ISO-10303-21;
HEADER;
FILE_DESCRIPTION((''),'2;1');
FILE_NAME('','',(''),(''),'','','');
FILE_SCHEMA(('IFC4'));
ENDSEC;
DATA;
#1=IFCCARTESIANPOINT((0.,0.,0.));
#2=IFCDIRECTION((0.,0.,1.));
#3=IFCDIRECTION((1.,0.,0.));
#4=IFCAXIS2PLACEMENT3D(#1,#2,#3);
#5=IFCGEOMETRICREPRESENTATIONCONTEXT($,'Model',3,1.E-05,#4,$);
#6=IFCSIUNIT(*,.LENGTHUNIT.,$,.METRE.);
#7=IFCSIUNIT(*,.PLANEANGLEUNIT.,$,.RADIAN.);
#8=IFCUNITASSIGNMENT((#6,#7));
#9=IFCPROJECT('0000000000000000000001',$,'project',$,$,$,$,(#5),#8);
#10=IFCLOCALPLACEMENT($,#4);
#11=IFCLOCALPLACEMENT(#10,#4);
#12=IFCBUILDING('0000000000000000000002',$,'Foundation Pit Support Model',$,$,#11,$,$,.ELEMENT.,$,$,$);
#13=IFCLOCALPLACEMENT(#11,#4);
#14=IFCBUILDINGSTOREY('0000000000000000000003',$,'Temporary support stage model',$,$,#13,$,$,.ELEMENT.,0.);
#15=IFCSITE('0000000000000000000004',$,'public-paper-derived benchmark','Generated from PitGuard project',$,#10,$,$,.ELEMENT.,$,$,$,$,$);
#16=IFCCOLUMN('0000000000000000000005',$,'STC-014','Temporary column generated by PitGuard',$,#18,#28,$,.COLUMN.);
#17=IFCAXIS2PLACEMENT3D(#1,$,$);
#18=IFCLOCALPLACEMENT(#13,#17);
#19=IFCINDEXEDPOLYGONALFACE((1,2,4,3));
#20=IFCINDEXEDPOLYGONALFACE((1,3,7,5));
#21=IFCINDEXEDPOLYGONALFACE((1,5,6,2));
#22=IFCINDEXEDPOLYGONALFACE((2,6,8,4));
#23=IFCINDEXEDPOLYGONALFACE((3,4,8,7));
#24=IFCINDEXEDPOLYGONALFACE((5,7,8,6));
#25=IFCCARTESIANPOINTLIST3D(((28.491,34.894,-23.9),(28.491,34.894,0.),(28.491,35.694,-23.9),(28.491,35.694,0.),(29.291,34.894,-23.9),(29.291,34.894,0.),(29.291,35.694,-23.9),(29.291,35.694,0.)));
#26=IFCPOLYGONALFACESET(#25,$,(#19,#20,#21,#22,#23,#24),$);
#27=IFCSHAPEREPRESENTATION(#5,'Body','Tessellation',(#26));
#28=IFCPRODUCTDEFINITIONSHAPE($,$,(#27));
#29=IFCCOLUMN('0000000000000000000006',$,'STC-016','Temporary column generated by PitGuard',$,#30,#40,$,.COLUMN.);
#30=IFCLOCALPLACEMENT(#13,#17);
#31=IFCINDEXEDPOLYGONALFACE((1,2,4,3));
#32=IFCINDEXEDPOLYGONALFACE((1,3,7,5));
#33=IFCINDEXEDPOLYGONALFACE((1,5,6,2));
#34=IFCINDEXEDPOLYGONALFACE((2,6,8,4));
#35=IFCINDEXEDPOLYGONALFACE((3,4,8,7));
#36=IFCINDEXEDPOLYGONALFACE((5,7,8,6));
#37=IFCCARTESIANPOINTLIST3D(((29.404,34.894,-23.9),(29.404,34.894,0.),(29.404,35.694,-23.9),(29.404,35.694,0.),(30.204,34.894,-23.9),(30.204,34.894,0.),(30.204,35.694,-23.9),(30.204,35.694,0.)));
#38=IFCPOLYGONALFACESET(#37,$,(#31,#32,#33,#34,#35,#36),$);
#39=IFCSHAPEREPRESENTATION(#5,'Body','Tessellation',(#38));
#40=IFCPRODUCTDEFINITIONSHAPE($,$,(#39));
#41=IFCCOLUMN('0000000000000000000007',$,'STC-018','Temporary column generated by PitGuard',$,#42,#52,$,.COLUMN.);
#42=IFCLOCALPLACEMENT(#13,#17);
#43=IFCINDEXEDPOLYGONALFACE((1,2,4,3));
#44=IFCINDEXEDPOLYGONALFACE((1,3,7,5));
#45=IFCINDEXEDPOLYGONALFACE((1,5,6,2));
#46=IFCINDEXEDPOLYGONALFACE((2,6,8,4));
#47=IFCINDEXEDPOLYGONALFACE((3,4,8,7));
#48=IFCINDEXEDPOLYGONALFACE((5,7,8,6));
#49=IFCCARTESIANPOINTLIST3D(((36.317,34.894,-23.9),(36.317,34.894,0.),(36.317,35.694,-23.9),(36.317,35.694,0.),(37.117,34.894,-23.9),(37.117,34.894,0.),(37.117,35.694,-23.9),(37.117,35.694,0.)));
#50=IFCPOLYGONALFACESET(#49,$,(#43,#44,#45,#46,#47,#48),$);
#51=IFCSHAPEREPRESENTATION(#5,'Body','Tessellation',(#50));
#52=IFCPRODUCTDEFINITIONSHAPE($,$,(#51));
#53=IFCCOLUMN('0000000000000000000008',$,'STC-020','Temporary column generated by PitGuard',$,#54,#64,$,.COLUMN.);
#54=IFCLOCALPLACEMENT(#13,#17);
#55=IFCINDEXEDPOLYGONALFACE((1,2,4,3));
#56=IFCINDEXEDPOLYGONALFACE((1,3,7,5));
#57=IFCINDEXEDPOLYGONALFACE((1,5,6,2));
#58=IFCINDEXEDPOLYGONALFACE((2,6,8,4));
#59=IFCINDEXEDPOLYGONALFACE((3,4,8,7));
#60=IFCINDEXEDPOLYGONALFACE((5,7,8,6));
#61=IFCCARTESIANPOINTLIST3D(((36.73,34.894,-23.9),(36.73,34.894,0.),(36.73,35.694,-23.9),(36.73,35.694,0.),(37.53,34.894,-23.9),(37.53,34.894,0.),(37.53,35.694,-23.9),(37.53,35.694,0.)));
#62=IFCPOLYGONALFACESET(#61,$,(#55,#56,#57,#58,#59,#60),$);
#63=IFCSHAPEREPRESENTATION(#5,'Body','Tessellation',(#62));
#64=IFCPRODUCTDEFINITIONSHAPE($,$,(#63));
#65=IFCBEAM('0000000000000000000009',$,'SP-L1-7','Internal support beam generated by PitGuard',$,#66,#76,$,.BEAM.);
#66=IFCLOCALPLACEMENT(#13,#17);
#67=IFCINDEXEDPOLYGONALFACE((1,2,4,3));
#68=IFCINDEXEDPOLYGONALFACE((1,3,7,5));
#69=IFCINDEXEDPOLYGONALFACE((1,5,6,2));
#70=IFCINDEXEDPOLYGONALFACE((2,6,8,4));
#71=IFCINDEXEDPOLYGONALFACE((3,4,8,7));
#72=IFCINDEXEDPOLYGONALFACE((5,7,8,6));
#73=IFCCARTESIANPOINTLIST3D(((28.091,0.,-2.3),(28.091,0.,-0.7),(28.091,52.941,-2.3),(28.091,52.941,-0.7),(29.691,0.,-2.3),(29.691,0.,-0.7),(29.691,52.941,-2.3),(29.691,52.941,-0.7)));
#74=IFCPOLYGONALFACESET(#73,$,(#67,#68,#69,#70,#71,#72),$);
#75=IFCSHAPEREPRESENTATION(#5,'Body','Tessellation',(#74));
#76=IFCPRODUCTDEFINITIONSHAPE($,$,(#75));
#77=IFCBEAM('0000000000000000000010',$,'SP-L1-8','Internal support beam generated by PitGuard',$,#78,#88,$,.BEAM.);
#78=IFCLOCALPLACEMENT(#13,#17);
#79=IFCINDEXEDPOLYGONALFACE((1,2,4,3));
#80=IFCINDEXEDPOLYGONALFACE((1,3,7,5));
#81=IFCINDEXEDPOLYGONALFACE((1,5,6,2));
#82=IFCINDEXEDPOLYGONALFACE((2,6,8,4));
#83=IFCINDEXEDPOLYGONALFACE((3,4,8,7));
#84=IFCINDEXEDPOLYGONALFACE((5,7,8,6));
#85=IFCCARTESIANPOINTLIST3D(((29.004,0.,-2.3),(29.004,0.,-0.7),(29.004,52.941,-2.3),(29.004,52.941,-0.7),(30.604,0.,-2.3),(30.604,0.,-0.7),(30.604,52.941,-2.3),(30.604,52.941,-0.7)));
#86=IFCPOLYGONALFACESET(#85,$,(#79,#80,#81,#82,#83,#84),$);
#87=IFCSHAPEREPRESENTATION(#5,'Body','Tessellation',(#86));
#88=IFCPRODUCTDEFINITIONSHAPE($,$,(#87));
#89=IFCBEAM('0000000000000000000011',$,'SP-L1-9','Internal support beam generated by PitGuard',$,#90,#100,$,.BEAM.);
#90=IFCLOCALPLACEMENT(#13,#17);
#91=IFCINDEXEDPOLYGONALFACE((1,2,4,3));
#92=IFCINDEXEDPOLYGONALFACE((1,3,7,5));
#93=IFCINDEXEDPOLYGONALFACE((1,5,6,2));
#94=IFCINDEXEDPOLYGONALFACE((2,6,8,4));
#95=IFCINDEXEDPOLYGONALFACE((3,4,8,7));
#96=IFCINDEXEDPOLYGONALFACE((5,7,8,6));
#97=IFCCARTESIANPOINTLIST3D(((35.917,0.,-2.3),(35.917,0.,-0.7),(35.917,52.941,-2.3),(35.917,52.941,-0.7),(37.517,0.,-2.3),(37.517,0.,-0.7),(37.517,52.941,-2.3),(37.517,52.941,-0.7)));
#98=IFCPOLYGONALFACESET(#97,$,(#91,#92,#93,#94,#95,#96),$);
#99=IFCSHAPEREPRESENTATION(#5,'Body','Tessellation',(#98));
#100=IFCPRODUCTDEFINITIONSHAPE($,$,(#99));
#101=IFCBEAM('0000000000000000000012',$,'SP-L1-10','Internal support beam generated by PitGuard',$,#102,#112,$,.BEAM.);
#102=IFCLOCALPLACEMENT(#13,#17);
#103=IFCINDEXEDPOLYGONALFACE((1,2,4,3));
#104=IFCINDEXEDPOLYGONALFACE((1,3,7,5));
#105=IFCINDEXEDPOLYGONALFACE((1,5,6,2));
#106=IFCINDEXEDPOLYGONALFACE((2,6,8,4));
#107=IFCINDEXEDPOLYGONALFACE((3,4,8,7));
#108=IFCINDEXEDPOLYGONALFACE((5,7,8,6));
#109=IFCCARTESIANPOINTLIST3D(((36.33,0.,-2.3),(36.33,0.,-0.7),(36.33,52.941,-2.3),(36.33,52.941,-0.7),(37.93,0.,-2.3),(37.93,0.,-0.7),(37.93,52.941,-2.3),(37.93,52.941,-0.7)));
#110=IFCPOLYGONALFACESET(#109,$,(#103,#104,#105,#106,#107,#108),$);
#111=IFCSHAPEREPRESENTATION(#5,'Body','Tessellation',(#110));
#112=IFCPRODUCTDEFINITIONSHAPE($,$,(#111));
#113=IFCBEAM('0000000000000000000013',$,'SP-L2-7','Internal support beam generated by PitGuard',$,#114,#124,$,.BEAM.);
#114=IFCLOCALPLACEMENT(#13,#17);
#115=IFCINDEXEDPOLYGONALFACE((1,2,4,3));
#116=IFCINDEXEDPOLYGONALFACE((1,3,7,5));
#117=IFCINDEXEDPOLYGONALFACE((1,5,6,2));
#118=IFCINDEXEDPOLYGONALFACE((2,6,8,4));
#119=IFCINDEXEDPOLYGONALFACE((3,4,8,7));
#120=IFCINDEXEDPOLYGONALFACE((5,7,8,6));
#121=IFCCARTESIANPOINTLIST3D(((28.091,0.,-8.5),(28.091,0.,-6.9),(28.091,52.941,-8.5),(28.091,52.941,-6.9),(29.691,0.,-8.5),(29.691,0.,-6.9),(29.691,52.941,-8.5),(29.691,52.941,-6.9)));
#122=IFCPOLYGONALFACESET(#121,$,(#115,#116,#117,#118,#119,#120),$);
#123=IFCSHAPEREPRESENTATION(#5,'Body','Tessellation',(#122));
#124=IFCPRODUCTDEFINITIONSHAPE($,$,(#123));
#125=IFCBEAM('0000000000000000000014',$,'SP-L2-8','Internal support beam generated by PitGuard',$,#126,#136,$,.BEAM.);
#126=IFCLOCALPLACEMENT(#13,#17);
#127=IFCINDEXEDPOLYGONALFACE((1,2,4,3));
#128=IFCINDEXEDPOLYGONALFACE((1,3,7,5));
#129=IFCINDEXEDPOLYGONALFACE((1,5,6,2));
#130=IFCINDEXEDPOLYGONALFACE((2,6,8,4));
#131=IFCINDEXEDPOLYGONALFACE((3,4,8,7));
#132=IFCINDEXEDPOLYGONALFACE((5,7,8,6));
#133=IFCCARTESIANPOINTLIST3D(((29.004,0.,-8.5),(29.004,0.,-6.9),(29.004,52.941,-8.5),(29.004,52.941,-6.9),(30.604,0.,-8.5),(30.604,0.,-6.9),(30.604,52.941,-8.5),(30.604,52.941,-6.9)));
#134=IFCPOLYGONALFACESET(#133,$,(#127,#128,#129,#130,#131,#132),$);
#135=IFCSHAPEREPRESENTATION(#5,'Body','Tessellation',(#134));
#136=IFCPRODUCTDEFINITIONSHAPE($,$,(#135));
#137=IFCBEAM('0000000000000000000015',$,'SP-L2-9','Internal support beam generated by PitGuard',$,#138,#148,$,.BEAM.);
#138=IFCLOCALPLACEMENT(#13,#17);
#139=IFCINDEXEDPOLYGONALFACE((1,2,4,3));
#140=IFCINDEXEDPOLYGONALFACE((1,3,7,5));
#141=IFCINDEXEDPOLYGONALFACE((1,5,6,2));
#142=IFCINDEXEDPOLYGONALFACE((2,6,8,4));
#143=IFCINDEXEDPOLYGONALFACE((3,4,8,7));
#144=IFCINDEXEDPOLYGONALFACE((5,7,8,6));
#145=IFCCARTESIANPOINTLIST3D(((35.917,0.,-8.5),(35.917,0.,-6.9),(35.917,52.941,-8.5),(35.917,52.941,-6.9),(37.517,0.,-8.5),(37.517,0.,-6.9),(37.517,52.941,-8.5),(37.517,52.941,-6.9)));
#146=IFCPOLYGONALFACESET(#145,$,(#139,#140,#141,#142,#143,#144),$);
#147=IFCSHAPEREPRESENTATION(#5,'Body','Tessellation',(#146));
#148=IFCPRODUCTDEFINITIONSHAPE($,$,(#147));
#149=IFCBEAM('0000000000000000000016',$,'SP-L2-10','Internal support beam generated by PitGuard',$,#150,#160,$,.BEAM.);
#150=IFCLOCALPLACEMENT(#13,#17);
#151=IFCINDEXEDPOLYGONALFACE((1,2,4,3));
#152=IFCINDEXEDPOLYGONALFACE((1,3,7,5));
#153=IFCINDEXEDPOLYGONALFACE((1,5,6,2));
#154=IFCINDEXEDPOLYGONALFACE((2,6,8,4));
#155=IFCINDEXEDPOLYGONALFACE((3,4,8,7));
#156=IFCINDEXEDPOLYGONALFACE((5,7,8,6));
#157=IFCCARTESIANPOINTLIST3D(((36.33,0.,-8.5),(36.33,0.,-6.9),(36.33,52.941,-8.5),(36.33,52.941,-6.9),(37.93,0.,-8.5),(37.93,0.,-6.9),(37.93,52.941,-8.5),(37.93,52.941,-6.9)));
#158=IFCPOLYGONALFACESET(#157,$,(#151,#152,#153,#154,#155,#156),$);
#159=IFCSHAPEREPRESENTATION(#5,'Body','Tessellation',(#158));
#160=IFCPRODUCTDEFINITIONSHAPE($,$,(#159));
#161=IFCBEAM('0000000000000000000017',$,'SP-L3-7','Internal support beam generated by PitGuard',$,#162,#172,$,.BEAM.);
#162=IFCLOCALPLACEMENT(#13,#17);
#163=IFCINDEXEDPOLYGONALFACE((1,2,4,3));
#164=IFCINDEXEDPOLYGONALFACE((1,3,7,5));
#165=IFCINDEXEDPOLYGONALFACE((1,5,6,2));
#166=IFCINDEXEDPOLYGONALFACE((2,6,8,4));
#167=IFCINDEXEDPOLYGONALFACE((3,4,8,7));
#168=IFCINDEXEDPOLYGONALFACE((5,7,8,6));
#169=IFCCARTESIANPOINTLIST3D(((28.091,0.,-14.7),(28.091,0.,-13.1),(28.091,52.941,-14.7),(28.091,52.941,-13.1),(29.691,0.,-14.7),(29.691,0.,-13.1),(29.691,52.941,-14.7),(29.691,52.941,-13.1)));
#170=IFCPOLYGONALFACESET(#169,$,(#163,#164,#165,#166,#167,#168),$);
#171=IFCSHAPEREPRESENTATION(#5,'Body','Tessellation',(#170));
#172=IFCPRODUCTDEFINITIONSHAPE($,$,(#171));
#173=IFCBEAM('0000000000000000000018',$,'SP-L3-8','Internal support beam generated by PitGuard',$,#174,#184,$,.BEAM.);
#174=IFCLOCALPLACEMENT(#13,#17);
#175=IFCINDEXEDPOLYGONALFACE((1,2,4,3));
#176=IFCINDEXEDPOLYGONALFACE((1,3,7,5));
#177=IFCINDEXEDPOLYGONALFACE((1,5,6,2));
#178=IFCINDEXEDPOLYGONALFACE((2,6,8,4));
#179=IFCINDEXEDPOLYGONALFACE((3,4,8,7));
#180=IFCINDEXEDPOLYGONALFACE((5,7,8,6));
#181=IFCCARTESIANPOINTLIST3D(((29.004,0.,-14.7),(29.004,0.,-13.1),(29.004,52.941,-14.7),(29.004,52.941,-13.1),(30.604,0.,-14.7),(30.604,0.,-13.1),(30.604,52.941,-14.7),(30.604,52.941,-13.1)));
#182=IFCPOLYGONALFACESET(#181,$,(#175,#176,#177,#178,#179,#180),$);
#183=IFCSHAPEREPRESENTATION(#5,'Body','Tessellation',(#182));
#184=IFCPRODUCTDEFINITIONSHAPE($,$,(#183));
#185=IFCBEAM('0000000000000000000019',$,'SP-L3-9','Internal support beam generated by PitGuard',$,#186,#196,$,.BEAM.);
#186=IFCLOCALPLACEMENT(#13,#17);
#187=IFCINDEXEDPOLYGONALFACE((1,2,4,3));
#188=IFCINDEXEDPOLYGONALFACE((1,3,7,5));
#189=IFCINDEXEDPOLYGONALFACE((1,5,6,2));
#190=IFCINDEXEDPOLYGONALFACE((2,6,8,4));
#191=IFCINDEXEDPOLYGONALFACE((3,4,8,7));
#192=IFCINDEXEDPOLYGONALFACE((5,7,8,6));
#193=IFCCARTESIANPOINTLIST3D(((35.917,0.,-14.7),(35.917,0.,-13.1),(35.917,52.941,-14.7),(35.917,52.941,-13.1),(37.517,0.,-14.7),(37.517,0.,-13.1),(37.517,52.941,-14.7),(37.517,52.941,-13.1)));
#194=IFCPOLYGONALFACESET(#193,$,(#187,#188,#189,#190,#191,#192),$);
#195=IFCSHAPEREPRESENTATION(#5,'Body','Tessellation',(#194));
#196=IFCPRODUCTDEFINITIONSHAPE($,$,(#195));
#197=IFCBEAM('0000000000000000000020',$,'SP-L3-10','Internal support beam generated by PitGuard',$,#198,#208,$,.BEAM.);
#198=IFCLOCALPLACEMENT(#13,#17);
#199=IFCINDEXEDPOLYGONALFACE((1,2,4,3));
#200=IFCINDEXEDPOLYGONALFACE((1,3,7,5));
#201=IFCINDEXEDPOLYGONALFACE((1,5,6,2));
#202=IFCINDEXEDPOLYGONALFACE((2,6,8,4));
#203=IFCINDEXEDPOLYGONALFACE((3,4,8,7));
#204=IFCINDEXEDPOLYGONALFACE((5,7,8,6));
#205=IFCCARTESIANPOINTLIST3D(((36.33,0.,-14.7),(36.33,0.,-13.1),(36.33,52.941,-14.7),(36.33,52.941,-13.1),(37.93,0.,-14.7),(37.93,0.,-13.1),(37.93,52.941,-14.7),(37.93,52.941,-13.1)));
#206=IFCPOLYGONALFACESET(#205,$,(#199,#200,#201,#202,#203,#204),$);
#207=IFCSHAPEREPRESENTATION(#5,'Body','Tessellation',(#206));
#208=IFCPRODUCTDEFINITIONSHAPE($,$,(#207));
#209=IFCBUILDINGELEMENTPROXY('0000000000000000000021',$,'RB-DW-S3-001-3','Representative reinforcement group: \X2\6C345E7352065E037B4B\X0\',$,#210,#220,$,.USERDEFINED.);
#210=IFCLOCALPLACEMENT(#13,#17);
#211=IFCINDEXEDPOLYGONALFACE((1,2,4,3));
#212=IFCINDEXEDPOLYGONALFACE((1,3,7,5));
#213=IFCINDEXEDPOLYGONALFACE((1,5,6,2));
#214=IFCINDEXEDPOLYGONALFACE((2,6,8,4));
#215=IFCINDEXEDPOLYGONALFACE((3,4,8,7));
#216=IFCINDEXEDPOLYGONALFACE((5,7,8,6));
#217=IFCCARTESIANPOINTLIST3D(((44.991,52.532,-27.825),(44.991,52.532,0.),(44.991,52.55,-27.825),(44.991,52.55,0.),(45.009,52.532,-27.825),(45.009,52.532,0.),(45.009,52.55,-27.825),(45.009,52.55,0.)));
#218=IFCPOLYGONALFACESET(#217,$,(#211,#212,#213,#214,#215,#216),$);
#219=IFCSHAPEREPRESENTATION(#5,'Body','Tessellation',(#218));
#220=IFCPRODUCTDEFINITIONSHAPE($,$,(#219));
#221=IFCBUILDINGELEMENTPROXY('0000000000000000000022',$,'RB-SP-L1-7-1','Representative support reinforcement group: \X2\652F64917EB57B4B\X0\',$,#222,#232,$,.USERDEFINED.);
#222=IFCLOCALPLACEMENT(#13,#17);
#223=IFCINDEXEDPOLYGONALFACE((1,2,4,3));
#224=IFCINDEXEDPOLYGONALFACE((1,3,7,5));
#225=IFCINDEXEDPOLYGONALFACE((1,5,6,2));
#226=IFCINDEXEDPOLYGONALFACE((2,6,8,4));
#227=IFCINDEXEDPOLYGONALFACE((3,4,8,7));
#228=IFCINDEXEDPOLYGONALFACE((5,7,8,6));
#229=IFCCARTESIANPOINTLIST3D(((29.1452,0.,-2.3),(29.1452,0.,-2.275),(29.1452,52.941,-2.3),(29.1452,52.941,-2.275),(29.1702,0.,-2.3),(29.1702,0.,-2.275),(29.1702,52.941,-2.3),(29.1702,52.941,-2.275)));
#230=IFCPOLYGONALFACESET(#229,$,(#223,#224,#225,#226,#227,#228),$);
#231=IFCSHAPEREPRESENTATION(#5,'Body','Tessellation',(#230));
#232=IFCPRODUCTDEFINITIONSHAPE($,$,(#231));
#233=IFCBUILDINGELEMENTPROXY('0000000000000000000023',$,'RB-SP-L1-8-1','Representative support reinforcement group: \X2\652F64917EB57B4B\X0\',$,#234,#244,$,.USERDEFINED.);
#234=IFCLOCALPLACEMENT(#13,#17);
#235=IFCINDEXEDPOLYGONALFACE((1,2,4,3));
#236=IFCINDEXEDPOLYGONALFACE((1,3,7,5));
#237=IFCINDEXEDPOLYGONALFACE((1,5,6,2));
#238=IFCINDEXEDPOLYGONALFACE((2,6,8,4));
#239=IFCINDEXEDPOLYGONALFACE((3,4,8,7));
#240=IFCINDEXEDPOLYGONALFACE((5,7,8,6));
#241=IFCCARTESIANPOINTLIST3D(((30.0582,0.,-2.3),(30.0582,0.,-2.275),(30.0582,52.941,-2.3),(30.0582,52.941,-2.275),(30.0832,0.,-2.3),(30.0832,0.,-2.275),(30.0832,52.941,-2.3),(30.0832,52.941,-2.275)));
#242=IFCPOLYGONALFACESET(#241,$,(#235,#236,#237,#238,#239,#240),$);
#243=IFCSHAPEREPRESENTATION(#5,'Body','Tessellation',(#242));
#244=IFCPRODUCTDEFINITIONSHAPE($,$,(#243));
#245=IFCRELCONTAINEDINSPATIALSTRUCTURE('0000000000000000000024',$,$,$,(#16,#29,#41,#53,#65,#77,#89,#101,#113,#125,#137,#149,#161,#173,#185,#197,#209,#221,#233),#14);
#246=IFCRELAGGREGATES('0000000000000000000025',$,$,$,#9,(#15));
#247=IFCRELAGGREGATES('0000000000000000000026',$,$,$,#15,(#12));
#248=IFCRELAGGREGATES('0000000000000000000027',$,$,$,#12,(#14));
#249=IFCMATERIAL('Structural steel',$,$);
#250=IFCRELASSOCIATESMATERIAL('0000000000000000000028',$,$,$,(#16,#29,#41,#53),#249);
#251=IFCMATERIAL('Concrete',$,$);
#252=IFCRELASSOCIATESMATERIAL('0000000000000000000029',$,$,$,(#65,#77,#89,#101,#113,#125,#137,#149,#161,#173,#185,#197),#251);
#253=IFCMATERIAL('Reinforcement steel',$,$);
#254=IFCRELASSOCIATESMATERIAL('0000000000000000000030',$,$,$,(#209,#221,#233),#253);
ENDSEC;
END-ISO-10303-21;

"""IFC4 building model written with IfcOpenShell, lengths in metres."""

from ifc_helpers import new_model, si_unit, frame, origin_with_axes, origin_2d, place, context, project, spatial, rectangle, extrude, material, element, save


model = new_model("IFC4")

# Units and contexts
model_context = context("Model", 3, precision=1e-05, world=origin_with_axes())
ifc_project = project(units=[si_unit("LENGTHUNIT", "METRE"), si_unit("PLANEANGLEUNIT", "RADIAN")], contexts=[model_context])

# Site, building, storey
site_placement = place(None, origin_with_axes())
site = spatial("IfcSite", under=ifc_project, at=site_placement, Name="public-paper-derived benchmark", Description="Generated from PitGuard project", CompositionType="ELEMENT")
building_placement = place(site_placement, origin_with_axes())
building = spatial("IfcBuilding", under=site, at=building_placement, Name="Foundation Pit Support Model", CompositionType="ELEMENT")
storey_placement = place(building_placement, origin_with_axes())
storey = spatial("IfcBuildingStorey", under=building, at=storey_placement, Name="Temporary support stage model", CompositionType="ELEMENT", Elevation=0.0)

# Columns
ifc_material_1 = material(Name="Structural steel")
for number, where, z_axis, x_axis, name in (
    (1, (28.891, 35.294, -23.9), (0.0, 0.0, 1.0), (1.0, 0.0, 0.0), "STC-014"),
    (2, (29.804, 35.294, -23.9), (0.0, 0.0, 1.0), (1.0, 0.0, 0.0), "STC-016"),
    (3, (36.717, 35.294, -23.9), (0.0, 0.0, 1.0), (1.0, 0.0, 0.0), "STC-018"),
    (4, (37.13, 35.294, -23.9), (0.0, 0.0, 1.0), (1.0, 0.0, 0.0), "STC-020"),
):
    element("IfcColumn", number, at=place(storey_placement, frame(where, z_axis=z_axis, x_axis=x_axis)), inside=storey, material=ifc_material_1, Name=name, Description="Temporary column generated by PitGuard", PredefinedType="COLUMN", context=model_context, shape_type="SweptSolid", body=[
        extrude(rectangle(XDim=0.8, YDim=0.8, at=origin_2d()), origin_with_axes(), (0.0, 0.0, 1.0), 23.9),
    ])

# Beams
ifc_material_2 = material(Name="Concrete")
for number, where, z_axis, x_axis, name in (
    (5, (28.891, 26.4705, -2.3), (0.0, 0.0, 1.0), (0.0, 1.0, 0.0), "SP-L1-7"),
    (6, (29.804, 26.4705, -2.3), (0.0, 0.0, 1.0), (0.0, 1.0, 0.0), "SP-L1-8"),
    (7, (36.717, 26.4705, -2.3), (0.0, 0.0, 1.0), (0.0, 1.0, 0.0), "SP-L1-9"),
    (8, (37.13, 26.4705, -2.3), (0.0, 0.0, 1.0), (0.0, 1.0, 0.0), "SP-L1-10"),
    (9, (28.891, 26.4705, -8.5), (0.0, 0.0, 1.0), (0.0, 1.0, 0.0), "SP-L2-7"),
    (10, (29.804, 26.4705, -8.5), (0.0, 0.0, 1.0), (0.0, 1.0, 0.0), "SP-L2-8"),
    (11, (36.717, 26.4705, -8.5), (0.0, 0.0, 1.0), (0.0, 1.0, 0.0), "SP-L2-9"),
    (12, (37.13, 26.4705, -8.5), (0.0, 0.0, 1.0), (0.0, 1.0, 0.0), "SP-L2-10"),
    (13, (28.891, 26.4705, -14.7), (0.0, 0.0, 1.0), (0.0, 1.0, 0.0), "SP-L3-7"),
    (14, (29.804, 26.4705, -14.7), (0.0, 0.0, 1.0), (0.0, 1.0, 0.0), "SP-L3-8"),
    (15, (36.717, 26.4705, -14.7), (0.0, 0.0, 1.0), (0.0, 1.0, 0.0), "SP-L3-9"),
    (16, (37.13, 26.4705, -14.7), (0.0, 0.0, 1.0), (0.0, 1.0, 0.0), "SP-L3-10"),
):
    element("IfcBeam", number, at=place(storey_placement, frame(where, z_axis=z_axis, x_axis=x_axis)), inside=storey, material=ifc_material_2, Name=name, Description="Internal support beam generated by PitGuard", PredefinedType="BEAM", context=model_context, shape_type="SweptSolid", body=[
        extrude(rectangle(XDim=52.941, YDim=1.6, at=origin_2d()), origin_with_axes(), (0.0, 0.0, 1.0), 1.6),
    ])

# Building element proxies
ifc_material_3 = material(Name="Reinforcement steel")
proxy_1_placement = place(storey_placement, frame((45.0, 52.541, -27.825), z_axis=(0.0, 0.0, 1.0), x_axis=(1.0, 0.0, 0.0)))
element("IfcBuildingElementProxy", 17, at=proxy_1_placement, inside=storey, material=ifc_material_3, Name="RB-DW-S3-001-3", Description="Representative reinforcement group: 水平分布筋", PredefinedType="USERDEFINED", context=model_context, shape_type="SweptSolid", body=[
    extrude(rectangle(XDim=0.018, YDim=0.018, at=origin_2d()), origin_with_axes(), (0.0, 0.0, 1.0), 27.825),
])
for number, where, z_axis, x_axis, name in (
    (18, (29.1577, 26.4705, -2.3), (0.0, 0.0, 1.0), (0.0, 1.0, 0.0), "RB-SP-L1-7-1"),
    (19, (30.0707, 26.4705, -2.3), (0.0, 0.0, 1.0), (0.0, 1.0, 0.0), "RB-SP-L1-8-1"),
):
    element("IfcBuildingElementProxy", number, at=place(storey_placement, frame(where, z_axis=z_axis, x_axis=x_axis)), inside=storey, material=ifc_material_3, Name=name, Description="Representative support reinforcement group: 支撑纵筋", PredefinedType="USERDEFINED", context=model_context, shape_type="SweptSolid", body=[
        extrude(rectangle(XDim=52.941, YDim=0.025, at=origin_2d()), origin_with_axes(), (0.0, 0.0, 1.0), 0.025),
    ])

save(model, "model.ifc")
